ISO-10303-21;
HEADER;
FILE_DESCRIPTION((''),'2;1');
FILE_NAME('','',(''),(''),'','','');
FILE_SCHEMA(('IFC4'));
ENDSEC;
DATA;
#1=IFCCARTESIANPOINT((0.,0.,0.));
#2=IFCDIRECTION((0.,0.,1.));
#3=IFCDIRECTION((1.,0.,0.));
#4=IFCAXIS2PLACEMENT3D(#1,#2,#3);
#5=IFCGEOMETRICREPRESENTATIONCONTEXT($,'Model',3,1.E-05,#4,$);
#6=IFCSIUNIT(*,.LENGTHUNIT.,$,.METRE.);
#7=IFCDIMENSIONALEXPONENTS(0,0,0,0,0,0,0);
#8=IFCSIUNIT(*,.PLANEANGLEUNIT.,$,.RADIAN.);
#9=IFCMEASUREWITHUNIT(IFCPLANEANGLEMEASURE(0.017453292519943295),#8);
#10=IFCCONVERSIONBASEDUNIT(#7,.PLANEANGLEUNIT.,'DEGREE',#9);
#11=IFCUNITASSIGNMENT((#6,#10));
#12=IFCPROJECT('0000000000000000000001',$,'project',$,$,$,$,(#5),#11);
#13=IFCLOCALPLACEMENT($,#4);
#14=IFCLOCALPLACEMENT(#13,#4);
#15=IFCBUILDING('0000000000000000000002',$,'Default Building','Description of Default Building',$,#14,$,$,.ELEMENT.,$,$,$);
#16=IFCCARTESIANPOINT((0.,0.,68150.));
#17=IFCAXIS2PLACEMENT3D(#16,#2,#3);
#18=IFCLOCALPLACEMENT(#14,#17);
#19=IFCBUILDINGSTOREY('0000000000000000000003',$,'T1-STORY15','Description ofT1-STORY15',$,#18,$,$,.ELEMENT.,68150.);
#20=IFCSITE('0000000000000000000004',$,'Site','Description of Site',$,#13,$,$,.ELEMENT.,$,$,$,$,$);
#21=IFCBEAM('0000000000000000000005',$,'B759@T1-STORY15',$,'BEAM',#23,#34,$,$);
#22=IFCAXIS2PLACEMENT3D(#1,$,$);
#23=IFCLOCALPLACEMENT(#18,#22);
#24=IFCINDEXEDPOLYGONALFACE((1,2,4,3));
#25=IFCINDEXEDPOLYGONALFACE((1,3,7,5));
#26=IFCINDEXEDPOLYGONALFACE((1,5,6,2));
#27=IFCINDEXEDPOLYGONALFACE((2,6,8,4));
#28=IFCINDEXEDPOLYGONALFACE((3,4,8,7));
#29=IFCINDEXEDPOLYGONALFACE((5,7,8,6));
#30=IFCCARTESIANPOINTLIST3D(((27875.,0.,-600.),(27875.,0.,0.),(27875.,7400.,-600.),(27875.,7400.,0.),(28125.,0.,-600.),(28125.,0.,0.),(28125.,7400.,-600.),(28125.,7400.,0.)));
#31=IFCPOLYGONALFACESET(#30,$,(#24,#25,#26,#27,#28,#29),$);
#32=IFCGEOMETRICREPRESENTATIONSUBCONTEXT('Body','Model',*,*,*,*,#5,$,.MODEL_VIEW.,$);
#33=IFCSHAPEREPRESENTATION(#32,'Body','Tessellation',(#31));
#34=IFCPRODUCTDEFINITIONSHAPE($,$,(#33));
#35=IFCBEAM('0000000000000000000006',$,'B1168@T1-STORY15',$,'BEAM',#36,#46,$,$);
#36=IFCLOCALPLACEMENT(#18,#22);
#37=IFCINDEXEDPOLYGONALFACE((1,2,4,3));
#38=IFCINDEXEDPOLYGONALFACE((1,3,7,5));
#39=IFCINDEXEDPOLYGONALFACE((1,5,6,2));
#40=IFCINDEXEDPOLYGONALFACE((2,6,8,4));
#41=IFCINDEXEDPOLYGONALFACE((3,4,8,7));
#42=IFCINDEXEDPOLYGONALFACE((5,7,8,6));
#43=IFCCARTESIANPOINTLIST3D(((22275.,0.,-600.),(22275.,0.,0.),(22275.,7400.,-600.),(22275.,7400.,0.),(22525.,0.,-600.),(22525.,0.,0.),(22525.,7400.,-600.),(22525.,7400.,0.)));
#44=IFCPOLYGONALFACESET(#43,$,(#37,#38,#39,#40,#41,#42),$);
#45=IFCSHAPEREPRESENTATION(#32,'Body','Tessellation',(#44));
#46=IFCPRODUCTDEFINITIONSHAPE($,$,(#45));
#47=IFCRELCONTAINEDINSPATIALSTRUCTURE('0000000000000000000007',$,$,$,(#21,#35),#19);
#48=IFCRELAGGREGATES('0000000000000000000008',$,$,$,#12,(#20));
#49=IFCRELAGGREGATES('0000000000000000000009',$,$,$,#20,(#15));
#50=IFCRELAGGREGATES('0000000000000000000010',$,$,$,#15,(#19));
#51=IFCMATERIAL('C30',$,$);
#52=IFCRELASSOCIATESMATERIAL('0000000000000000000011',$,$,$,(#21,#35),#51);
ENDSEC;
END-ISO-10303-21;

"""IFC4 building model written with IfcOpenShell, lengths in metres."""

from ifc_helpers import new_model, entity, si_unit, converted_unit, frame, origin_with_axes, place, context, subcontext, project, spatial, rectangle, extrude, material, element, save


model = new_model("IFC4")

# Units and contexts
model_context = context("Model", 3, precision=1e-05, world=origin_with_axes())
body_context = subcontext(model_context, "Body", "Model", "MODEL_VIEW")
ifc_project = project(units=[si_unit("LENGTHUNIT", "METRE"), converted_unit("PLANEANGLEUNIT", "DEGREE", entity("IfcPlaneAngleMeasure", 0.017453292519943295), si_unit("PLANEANGLEUNIT", "RADIAN"), dimensions=[0, 0, 0, 0, 0, 0, 0])], contexts=[model_context])

# Site, building, storey
site_placement = place(None, origin_with_axes())
site = spatial("IfcSite", under=ifc_project, at=site_placement, Name="Site", Description="Description of Site", CompositionType="ELEMENT")
building_placement = place(site_placement, origin_with_axes())
building = spatial("IfcBuilding", under=site, at=building_placement, Name="Default Building", Description="Description of Default Building", CompositionType="ELEMENT")
storey_placement = place(building_placement, frame((0.0, 0.0, 68150.0), z_axis=(0.0, 0.0, 1.0), x_axis=(1.0, 0.0, 0.0)))
storey = spatial("IfcBuildingStorey", under=building, at=storey_placement, Name="T1-STORY15", Description="Description ofT1-STORY15", CompositionType="ELEMENT", Elevation=68150.0)

# Beams
ifc_material_1 = material(Name="C30")
for number, where, z_axis, x_axis, name in (
    (1, (28000.0, 0.0, -300.0), (0.0, 1.0, 0.0), (-1.0, 0.0, 0.0), "B759@T1-STORY15"),
    (2, (22400.0, 0.0, -300.0), (0.0, 1.0, 0.0), (-1.0, 0.0, 0.0), "B1168@T1-STORY15"),
):
    element("IfcBeam", number, at=place(storey_placement, frame(where, z_axis=z_axis, x_axis=x_axis)), inside=storey, material=ifc_material_1, Name=name, ObjectType="BEAM", context=body_context, shape_type="SweptSolid", body=[
        extrude(rectangle(XDim=250.0, YDim=600.0), origin_with_axes(), (0.0, 0.0, 1.0), 7400.0),
    ])

save(model, "model.ifc")
